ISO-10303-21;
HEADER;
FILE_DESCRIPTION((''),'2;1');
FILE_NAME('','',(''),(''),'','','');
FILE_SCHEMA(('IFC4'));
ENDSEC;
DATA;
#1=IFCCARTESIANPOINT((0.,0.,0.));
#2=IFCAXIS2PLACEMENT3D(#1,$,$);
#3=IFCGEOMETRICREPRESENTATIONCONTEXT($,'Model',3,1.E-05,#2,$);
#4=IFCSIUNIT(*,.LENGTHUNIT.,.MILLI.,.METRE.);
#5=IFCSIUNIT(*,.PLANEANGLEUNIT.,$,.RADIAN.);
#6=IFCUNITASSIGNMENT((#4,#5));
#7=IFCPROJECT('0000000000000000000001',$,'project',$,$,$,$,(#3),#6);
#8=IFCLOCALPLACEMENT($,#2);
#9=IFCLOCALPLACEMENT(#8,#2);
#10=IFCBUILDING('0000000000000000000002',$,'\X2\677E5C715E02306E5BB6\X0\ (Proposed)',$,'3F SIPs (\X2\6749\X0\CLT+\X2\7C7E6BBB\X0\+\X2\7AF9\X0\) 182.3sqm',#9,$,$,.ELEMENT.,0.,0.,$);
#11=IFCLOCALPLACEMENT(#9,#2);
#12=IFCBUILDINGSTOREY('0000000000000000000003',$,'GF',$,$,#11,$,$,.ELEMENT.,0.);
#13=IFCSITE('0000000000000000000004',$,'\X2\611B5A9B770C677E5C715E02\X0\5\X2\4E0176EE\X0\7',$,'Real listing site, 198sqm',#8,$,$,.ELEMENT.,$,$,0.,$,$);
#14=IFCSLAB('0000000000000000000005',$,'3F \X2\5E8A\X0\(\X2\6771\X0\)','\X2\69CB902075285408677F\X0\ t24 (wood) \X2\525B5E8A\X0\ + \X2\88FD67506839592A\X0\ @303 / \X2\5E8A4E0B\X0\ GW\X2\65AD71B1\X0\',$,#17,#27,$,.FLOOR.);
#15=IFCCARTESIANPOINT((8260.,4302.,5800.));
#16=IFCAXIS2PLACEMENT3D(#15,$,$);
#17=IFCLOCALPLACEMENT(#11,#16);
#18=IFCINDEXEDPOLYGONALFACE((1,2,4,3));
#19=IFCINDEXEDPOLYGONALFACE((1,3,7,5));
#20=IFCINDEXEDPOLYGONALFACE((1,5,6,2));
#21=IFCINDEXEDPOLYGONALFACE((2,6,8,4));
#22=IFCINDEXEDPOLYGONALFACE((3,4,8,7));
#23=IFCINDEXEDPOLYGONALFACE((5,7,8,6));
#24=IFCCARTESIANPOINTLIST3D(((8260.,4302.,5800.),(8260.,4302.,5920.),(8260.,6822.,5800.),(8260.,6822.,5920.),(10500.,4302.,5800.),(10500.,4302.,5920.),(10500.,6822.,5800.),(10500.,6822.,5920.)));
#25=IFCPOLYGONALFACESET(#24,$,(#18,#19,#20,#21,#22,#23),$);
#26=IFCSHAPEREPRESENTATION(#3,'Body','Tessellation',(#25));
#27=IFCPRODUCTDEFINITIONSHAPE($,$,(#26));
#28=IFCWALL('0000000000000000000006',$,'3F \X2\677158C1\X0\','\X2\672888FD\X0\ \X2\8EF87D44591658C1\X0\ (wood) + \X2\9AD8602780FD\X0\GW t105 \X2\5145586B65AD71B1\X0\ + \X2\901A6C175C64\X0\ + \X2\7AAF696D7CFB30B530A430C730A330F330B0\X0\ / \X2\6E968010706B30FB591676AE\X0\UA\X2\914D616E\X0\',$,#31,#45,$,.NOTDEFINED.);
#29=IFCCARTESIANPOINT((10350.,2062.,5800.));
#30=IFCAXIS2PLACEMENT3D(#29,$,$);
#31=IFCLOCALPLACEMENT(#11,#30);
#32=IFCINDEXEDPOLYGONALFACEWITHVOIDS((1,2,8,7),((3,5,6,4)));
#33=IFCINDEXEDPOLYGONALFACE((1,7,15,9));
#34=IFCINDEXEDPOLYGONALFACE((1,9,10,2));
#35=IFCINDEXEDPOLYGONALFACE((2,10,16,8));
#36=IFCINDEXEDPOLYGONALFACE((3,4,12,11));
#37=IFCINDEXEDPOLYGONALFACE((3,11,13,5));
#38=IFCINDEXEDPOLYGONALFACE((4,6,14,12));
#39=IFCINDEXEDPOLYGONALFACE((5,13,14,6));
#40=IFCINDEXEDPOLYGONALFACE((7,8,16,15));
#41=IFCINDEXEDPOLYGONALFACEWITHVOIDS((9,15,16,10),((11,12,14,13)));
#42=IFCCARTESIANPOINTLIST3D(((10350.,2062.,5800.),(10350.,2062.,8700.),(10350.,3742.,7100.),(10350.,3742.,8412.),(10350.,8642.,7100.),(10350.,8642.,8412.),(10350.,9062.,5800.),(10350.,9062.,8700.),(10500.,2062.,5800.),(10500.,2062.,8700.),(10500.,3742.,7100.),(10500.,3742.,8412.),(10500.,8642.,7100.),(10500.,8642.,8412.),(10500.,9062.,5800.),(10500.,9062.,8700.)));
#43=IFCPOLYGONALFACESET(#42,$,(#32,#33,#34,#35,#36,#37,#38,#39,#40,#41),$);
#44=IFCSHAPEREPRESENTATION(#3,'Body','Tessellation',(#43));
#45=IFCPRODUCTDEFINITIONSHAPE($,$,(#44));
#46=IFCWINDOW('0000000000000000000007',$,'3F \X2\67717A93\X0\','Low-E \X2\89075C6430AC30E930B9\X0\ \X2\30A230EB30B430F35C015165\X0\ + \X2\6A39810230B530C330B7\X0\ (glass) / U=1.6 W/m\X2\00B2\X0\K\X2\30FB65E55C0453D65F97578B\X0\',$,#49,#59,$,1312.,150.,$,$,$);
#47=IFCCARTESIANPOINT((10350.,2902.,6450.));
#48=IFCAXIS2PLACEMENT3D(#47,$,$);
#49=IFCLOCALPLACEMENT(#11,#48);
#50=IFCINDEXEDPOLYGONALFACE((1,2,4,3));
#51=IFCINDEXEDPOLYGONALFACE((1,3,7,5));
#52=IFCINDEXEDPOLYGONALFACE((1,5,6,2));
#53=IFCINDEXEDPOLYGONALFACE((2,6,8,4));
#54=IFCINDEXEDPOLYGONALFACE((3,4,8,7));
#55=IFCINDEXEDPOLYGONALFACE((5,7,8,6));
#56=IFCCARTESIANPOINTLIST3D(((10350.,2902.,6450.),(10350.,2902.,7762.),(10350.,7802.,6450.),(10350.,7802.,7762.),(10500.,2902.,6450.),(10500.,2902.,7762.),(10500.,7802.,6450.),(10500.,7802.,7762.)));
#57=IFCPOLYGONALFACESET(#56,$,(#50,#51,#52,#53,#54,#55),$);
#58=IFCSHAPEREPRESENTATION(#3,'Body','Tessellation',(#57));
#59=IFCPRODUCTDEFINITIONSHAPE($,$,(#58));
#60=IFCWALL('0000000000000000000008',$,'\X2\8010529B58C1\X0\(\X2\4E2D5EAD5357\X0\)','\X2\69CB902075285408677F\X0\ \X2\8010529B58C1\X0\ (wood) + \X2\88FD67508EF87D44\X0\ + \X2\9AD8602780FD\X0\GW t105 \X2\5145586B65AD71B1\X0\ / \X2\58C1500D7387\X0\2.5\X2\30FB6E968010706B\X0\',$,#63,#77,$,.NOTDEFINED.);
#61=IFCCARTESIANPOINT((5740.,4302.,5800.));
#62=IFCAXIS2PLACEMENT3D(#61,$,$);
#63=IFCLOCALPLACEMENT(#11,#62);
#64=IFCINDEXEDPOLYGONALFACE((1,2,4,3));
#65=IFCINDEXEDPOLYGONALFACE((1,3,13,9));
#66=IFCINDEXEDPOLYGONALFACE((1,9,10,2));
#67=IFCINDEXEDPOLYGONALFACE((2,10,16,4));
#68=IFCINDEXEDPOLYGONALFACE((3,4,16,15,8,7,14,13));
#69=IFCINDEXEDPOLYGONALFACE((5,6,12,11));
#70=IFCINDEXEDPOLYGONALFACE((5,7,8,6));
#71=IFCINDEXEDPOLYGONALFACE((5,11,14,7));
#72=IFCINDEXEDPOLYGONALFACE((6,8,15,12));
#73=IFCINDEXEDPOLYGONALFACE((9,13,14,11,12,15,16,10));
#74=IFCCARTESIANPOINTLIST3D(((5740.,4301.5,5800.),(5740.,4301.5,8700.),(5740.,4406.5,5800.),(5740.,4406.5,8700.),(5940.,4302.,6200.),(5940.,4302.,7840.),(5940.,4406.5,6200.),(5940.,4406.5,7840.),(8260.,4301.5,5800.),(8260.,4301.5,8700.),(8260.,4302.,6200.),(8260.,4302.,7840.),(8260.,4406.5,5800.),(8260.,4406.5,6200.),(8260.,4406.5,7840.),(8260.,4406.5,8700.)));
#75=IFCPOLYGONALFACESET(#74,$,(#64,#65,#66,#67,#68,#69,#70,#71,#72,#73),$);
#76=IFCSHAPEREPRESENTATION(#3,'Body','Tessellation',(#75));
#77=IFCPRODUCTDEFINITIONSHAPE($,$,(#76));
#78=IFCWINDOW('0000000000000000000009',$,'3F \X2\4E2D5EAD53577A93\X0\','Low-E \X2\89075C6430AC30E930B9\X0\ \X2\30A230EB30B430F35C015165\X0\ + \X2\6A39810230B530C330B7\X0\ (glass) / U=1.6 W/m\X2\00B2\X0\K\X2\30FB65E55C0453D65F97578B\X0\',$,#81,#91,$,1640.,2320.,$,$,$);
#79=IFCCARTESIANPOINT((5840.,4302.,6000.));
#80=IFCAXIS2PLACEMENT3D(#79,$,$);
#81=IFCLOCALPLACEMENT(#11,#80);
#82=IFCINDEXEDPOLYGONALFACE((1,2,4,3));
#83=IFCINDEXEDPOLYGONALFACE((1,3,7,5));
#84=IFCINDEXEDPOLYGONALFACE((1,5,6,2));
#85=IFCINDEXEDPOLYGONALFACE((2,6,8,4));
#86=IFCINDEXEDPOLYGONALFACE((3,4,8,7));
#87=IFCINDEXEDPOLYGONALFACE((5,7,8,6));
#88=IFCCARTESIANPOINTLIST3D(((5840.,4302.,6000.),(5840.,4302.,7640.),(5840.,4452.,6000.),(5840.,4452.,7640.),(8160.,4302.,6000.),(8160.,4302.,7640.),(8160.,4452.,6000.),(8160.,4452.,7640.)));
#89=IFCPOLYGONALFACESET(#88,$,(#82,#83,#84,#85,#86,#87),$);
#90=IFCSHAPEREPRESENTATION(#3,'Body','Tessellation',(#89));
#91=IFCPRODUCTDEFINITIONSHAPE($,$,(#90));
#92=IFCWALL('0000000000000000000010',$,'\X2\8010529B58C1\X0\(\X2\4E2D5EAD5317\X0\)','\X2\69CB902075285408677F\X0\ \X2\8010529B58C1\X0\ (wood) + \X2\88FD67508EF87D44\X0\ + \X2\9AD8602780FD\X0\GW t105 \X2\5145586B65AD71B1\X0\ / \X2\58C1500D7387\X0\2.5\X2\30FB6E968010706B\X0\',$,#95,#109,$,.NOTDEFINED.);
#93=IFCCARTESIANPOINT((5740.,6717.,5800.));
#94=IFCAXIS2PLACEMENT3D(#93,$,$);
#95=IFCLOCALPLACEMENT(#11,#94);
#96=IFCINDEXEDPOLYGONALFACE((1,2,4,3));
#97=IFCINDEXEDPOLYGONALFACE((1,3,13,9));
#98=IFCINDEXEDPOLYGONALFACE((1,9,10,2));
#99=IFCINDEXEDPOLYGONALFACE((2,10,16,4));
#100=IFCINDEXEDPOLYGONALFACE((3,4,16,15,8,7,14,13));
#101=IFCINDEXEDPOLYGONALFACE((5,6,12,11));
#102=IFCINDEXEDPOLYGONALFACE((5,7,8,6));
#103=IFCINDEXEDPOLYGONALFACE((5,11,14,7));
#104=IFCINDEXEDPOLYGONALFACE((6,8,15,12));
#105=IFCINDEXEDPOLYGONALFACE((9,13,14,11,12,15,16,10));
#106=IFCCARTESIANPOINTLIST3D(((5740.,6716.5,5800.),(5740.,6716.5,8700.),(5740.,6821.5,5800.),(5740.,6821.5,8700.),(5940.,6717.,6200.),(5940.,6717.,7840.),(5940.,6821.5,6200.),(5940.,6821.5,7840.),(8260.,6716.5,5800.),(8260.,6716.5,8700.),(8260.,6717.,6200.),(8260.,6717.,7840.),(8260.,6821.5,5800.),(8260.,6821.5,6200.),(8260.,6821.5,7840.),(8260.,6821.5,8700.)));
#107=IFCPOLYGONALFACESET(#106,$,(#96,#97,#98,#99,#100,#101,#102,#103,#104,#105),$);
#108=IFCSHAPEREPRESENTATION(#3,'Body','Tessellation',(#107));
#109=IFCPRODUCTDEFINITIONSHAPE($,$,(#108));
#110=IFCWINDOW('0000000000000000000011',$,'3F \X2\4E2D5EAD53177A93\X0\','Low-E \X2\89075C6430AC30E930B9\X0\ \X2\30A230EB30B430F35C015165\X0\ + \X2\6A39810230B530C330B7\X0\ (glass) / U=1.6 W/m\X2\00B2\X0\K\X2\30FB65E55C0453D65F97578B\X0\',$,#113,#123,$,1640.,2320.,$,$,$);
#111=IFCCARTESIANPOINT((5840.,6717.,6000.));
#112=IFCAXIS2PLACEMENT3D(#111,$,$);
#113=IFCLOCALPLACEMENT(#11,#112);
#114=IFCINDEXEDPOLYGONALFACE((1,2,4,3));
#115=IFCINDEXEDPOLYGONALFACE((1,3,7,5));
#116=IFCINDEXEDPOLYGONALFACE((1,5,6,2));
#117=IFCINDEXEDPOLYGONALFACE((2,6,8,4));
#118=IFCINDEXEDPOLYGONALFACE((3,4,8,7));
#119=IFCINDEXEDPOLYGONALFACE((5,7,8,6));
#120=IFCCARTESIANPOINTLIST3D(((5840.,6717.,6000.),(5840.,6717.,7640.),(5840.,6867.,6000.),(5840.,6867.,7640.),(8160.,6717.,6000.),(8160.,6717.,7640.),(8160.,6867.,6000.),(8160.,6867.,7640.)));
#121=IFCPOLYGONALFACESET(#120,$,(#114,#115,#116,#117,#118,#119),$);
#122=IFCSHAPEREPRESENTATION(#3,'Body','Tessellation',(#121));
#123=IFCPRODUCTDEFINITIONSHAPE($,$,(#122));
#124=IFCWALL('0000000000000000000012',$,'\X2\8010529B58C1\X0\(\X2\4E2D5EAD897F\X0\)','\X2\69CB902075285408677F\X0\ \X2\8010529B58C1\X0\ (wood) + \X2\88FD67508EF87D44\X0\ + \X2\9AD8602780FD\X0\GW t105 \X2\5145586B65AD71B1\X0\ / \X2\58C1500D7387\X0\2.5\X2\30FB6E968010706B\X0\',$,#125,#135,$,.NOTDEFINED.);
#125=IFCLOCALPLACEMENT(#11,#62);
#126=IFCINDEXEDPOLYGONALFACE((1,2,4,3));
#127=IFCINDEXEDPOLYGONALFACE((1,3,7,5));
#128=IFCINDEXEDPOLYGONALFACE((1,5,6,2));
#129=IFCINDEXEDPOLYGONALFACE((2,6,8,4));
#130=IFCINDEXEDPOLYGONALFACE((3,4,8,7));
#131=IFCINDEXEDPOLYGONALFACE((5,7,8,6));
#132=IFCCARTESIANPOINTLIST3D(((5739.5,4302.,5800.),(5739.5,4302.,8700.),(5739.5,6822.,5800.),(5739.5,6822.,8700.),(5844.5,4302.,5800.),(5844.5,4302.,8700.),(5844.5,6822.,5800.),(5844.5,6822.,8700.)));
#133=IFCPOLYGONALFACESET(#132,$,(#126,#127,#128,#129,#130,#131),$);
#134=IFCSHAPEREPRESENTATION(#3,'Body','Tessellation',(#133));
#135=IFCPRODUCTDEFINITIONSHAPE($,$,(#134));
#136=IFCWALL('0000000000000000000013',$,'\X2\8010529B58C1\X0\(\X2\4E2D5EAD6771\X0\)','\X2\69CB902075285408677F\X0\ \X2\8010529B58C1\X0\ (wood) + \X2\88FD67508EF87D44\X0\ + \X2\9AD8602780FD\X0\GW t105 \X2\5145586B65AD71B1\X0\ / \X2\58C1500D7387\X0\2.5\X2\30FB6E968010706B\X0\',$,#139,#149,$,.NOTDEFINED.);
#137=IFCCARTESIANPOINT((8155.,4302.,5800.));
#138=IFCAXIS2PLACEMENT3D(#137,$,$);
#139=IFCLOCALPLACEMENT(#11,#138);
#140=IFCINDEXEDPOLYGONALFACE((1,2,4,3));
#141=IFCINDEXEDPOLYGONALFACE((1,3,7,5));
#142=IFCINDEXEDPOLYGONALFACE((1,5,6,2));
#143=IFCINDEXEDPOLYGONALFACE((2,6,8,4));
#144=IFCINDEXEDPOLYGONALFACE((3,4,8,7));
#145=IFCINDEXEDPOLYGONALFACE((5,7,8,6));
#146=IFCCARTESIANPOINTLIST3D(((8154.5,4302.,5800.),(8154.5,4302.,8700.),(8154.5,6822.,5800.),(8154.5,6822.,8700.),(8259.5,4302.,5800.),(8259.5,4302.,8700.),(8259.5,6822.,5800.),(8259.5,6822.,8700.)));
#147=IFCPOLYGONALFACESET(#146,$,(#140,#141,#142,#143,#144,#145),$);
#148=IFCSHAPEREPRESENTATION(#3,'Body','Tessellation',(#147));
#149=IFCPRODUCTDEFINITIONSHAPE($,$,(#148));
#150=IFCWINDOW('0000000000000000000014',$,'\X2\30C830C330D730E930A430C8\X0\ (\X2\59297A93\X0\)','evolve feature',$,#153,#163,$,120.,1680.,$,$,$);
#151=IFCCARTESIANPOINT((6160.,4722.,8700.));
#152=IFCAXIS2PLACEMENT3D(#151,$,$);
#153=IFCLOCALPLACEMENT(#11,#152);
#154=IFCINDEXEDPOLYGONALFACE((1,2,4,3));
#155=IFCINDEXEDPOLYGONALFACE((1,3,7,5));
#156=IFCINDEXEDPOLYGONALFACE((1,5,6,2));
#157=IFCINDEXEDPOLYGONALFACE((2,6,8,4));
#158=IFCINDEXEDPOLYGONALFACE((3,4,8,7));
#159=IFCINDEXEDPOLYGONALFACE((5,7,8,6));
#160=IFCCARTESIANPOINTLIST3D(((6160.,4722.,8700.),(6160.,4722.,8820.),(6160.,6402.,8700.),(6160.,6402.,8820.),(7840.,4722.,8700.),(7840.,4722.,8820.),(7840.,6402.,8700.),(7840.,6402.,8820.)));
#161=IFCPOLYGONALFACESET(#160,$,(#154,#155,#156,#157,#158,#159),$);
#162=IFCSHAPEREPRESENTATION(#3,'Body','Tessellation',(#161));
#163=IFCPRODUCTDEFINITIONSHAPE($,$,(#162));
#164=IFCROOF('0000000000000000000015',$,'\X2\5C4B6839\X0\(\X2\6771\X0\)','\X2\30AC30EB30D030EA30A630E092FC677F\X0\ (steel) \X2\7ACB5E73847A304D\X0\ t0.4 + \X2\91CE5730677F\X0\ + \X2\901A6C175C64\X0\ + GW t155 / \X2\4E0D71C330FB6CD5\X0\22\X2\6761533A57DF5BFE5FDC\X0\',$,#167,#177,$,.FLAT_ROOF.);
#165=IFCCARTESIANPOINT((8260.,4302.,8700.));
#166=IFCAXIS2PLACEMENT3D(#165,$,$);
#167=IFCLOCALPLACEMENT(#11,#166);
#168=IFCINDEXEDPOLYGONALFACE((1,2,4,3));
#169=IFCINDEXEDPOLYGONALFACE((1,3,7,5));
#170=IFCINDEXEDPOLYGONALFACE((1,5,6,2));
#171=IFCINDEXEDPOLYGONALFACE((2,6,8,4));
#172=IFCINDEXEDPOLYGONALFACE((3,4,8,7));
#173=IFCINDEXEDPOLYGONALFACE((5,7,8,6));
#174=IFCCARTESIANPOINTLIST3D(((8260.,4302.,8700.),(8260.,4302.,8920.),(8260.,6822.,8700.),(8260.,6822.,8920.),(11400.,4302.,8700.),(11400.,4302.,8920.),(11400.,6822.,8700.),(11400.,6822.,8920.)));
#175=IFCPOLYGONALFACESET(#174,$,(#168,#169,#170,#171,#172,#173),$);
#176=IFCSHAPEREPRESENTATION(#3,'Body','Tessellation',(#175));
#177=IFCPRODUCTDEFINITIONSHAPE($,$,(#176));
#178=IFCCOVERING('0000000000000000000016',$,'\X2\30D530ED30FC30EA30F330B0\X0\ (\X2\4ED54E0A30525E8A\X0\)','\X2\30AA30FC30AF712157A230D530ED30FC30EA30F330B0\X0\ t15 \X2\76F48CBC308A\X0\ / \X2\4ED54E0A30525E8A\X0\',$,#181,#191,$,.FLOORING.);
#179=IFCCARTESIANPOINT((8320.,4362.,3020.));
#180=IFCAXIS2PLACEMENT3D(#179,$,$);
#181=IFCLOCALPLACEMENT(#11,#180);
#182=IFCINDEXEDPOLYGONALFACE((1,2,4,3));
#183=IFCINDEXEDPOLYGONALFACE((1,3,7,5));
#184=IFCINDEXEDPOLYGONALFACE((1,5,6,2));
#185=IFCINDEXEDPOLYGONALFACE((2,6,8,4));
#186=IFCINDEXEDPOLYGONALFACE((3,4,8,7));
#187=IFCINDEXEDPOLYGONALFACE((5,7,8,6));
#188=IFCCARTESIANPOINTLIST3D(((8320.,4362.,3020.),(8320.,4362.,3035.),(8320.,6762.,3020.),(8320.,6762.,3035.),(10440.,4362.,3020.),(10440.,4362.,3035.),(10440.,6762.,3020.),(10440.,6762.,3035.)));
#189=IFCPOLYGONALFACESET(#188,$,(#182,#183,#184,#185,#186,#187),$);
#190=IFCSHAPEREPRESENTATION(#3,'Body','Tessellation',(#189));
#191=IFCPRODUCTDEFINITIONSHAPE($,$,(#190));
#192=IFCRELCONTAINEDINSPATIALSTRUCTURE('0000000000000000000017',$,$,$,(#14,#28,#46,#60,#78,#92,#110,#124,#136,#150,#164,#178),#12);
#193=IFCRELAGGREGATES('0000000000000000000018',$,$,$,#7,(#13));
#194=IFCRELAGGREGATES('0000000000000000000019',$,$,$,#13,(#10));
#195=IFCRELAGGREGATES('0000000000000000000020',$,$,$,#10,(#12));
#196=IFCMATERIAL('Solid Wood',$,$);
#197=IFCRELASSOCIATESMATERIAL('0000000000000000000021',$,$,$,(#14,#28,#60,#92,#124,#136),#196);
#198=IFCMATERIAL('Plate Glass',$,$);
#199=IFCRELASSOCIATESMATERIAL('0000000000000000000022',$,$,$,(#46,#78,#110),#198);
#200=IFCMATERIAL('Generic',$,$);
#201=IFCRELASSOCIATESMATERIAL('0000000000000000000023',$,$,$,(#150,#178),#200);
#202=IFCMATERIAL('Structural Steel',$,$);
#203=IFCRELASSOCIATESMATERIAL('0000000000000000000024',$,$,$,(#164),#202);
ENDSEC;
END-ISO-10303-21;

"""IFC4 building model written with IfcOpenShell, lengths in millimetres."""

from ifc_helpers import new_model, si_unit, frame, frame_2d, origin, place, context, project, spatial, rectangle, extrude, material, element, fill, save


model = new_model("IFC4")

# Units and contexts
model_context = context("Model", 3, precision=1e-05, world=origin())
ifc_project = project(units=[si_unit("LENGTHUNIT", "METRE", prefix="MILLI"), si_unit("PLANEANGLEUNIT", "RADIAN")], contexts=[model_context])

# Site, building, storey
site_placement = place(None, origin())
site = spatial("IfcSite", under=ifc_project, at=site_placement, Name="愛媛県松山市5丁目7", ObjectType="Real listing site, 198sqm", CompositionType="ELEMENT", RefElevation=0.0)
building_placement = place(site_placement, origin())
building = spatial("IfcBuilding", under=site, at=building_placement, Name="松山市の家 (Proposed)", ObjectType="3F SIPs (杉CLT+籾殻+竹) 182.3sqm", CompositionType="ELEMENT", ElevationOfRefHeight=0.0, ElevationOfTerrain=0.0)
storey_placement = place(building_placement, origin())
storey = spatial("IfcBuildingStorey", under=building, at=storey_placement, Name="GF", CompositionType="ELEMENT", Elevation=0.0)

# Slab
ifc_material_1 = material(Name="Solid Wood")
slab_placement = place(storey_placement, frame((8260.0, 4302.0, 5800.0)))
element("IfcSlab", 1, at=slab_placement, inside=storey, material=ifc_material_1, Name="3F 床(東)", Description="構造用合板 t24 (wood) 剛床 + 製材根太 @303 / 床下 GW断熱", PredefinedType="FLOOR", context=model_context, shape_type="SweptSolid", body=[
    extrude(rectangle(XDim=2240.0, YDim=2520.0, at=frame_2d((1120.0, 1260.0))), frame((8260.0, 4302.0, 5800.0)), (0.0, 0.0, 1.0), 120.0),
])

# Walls, openings, windows
wall_1_placement = place(storey_placement, frame((10350.0, 2062.0, 5800.0)))
wall_1 = element("IfcWall", 2, at=wall_1_placement, inside=storey, material=ifc_material_1, Name="3F 東壁", Description="木製 軸組外壁 (wood) + 高性能GW t105 充填断熱 + 通気層 + 窯業系サイディング / 準耐火・外皮UA配慮", PredefinedType="NOTDEFINED", context=model_context, shape_type="SweptSolid", body=[
    extrude(rectangle(XDim=150.0, YDim=7000.0, at=frame_2d((75.0, 3500.0))), frame((10350.0, 2062.0, 5800.0)), (0.0, 0.0, 1.0), 2900.0),
])
opening_1_placement = place(storey_placement, frame((10350.0, 2902.0, 6450.0)))
opening_1 = element("IfcOpeningElement", 3, at=opening_1_placement, cuts=wall_1, PredefinedType="NOTDEFINED", context=model_context, shape_type="SweptSolid", body=[
    extrude(rectangle(XDim=150.0, YDim=4900.0, at=frame_2d((75.0, 2450.0))), frame((10350.0, 2902.0, 6450.0)), (0.0, 0.0, 1.0), 1312.0),
])
ifc_material_2 = material(Name="Plate Glass")
window_1_placement = place(storey_placement, frame((10350.0, 2902.0, 6450.0)))
window_1 = element("IfcWindow", 4, at=window_1_placement, inside=storey, material=ifc_material_2, Name="3F 東窓", Description="Low-E 複層ガラス アルゴン封入 + 樹脂サッシ (glass) / U=1.6 W/m²K・日射取得型", OverallHeight=1312.0, OverallWidth=150.0, context=model_context, shape_type="SweptSolid", body=[
    extrude(rectangle(XDim=150.0, YDim=4900.0, at=frame_2d((75.0, 2450.0))), frame((10350.0, 2902.0, 6450.0)), (0.0, 0.0, 1.0), 1312.0),
])
fill(opening_1, window_1)
wall_2_placement = place(storey_placement, frame((5740.0, 4302.0, 5800.0)))
wall_2 = element("IfcWall", 5, at=wall_2_placement, inside=storey, material=ifc_material_1, Name="耐力壁(中庭南)", Description="構造用合板 耐力壁 (wood) + 製材軸組 + 高性能GW t105 充填断熱 / 壁倍率2.5・準耐火", PredefinedType="NOTDEFINED", context=model_context, shape_type="SweptSolid", body=[
    extrude(rectangle(XDim=2520.0, YDim=105.0, at=frame_2d((1260.0, 52.0))), frame((5740.0, 4302.0, 5800.0)), (0.0, 0.0, 1.0), 2900.0),
])
opening_2_placement = place(storey_placement, frame((5840.0, 4302.0, 6000.0)))
opening_2 = element("IfcOpeningElement", 6, at=opening_2_placement, cuts=wall_2, PredefinedType="NOTDEFINED", context=model_context, shape_type="SweptSolid", body=[
    extrude(rectangle(XDim=2320.0, YDim=150.0, at=frame_2d((1160.0, 75.0))), frame((5840.0, 4302.0, 6000.0)), (0.0, 0.0, 1.0), 1640.0),
])
window_2_placement = place(storey_placement, frame((5840.0, 4302.0, 6000.0)))
window_2 = element("IfcWindow", 7, at=window_2_placement, inside=storey, material=ifc_material_2, Name="3F 中庭南窓", Description="Low-E 複層ガラス アルゴン封入 + 樹脂サッシ (glass) / U=1.6 W/m²K・日射取得型", OverallHeight=1640.0, OverallWidth=2320.0, context=model_context, shape_type="SweptSolid", body=[
    extrude(rectangle(XDim=2320.0, YDim=150.0, at=frame_2d((1160.0, 75.0))), frame((5840.0, 4302.0, 6000.0)), (0.0, 0.0, 1.0), 1640.0),
])
fill(opening_2, window_2)
wall_3_placement = place(storey_placement, frame((5740.0, 6717.0, 5800.0)))
wall_3 = element("IfcWall", 8, at=wall_3_placement, inside=storey, material=ifc_material_1, Name="耐力壁(中庭北)", Description="構造用合板 耐力壁 (wood) + 製材軸組 + 高性能GW t105 充填断熱 / 壁倍率2.5・準耐火", PredefinedType="NOTDEFINED", context=model_context, shape_type="SweptSolid", body=[
    extrude(rectangle(XDim=2520.0, YDim=105.0, at=frame_2d((1260.0, 52.0))), frame((5740.0, 6717.0, 5800.0)), (0.0, 0.0, 1.0), 2900.0),
])
opening_3_placement = place(storey_placement, frame((5840.0, 6717.0, 6000.0)))
opening_3 = element("IfcOpeningElement", 9, at=opening_3_placement, cuts=wall_3, PredefinedType="NOTDEFINED", context=model_context, shape_type="SweptSolid", body=[
    extrude(rectangle(XDim=2320.0, YDim=150.0, at=frame_2d((1160.0, 75.0))), frame((5840.0, 6717.0, 6000.0)), (0.0, 0.0, 1.0), 1640.0),
])
window_3_placement = place(storey_placement, frame((5840.0, 6717.0, 6000.0)))
window_3 = element("IfcWindow", 10, at=window_3_placement, inside=storey, material=ifc_material_2, Name="3F 中庭北窓", Description="Low-E 複層ガラス アルゴン封入 + 樹脂サッシ (glass) / U=1.6 W/m²K・日射取得型", OverallHeight=1640.0, OverallWidth=2320.0, context=model_context, shape_type="SweptSolid", body=[
    extrude(rectangle(XDim=2320.0, YDim=150.0, at=frame_2d((1160.0, 75.0))), frame((5840.0, 6717.0, 6000.0)), (0.0, 0.0, 1.0), 1640.0),
])
fill(opening_3, window_3)

# Walls
wall_4_placement = place(storey_placement, frame((5740.0, 4302.0, 5800.0)))
element("IfcWall", 11, at=wall_4_placement, inside=storey, material=ifc_material_1, Name="耐力壁(中庭西)", Description="構造用合板 耐力壁 (wood) + 製材軸組 + 高性能GW t105 充填断熱 / 壁倍率2.5・準耐火", PredefinedType="NOTDEFINED", context=model_context, shape_type="SweptSolid", body=[
    extrude(rectangle(XDim=105.0, YDim=2520.0, at=frame_2d((52.0, 1260.0))), frame((5740.0, 4302.0, 5800.0)), (0.0, 0.0, 1.0), 2900.0),
])
wall_5_placement = place(storey_placement, frame((8155.0, 4302.0, 5800.0)))
element("IfcWall", 12, at=wall_5_placement, inside=storey, material=ifc_material_1, Name="耐力壁(中庭東)", Description="構造用合板 耐力壁 (wood) + 製材軸組 + 高性能GW t105 充填断熱 / 壁倍率2.5・準耐火", PredefinedType="NOTDEFINED", context=model_context, shape_type="SweptSolid", body=[
    extrude(rectangle(XDim=105.0, YDim=2520.0, at=frame_2d((52.0, 1260.0))), frame((8155.0, 4302.0, 5800.0)), (0.0, 0.0, 1.0), 2900.0),
])

# Window
ifc_material_3 = material(Name="Generic")
window_4_placement = place(storey_placement, frame((6160.0, 4722.0, 8700.0)))
element("IfcWindow", 13, at=window_4_placement, inside=storey, material=ifc_material_3, Name="トップライト (天窓)", Description="evolve feature", OverallHeight=120.0, OverallWidth=1680.0, context=model_context, shape_type="SweptSolid", body=[
    extrude(rectangle(XDim=1680.0, YDim=1680.0, at=frame_2d((840.0, 840.0))), frame((6160.0, 4722.0, 8700.0)), (0.0, 0.0, 1.0), 120.0),
])

# Roof
ifc_material_4 = material(Name="Structural Steel")
for number, where, name in (
    (14, (8260.0, 4302.0, 8700.0), "屋根(東)"),
):
    element("IfcRoof", number, at=place(storey_placement, frame(where)), inside=storey, material=ifc_material_4, Name=name, Description="ガルバリウム鋼板 (steel) 立平葺き t0.4 + 野地板 + 通気層 + GW t155 / 不燃・法22条区域対応", PredefinedType="FLAT_ROOF", context=model_context, shape_type="SweptSolid", body=[
        extrude(rectangle(XDim=3140.0, YDim=2520.0, at=frame_2d((1570.0, 1260.0))), frame((8260.0, 4302.0, 8700.0)), (0.0, 0.0, 1.0), 220.0),
    ])

# Covering
covering_1_placement = place(storey_placement, frame((8320.0, 4362.0, 3020.0)))
element("IfcCovering", 15, at=covering_1_placement, inside=storey, material=ifc_material_3, Name="フローリング (仕上げ床)", Description="オーク無垢フローリング t15 直貼り / 仕上げ床", PredefinedType="FLOORING", context=model_context, shape_type="SweptSolid", body=[
    extrude(rectangle(XDim=2120.0, YDim=2400.0, at=frame_2d((1060.0, 1200.0))), frame((8320.0, 4362.0, 3020.0)), (0.0, 0.0, 1.0), 15.0),
])

save(model, "model.ifc")
